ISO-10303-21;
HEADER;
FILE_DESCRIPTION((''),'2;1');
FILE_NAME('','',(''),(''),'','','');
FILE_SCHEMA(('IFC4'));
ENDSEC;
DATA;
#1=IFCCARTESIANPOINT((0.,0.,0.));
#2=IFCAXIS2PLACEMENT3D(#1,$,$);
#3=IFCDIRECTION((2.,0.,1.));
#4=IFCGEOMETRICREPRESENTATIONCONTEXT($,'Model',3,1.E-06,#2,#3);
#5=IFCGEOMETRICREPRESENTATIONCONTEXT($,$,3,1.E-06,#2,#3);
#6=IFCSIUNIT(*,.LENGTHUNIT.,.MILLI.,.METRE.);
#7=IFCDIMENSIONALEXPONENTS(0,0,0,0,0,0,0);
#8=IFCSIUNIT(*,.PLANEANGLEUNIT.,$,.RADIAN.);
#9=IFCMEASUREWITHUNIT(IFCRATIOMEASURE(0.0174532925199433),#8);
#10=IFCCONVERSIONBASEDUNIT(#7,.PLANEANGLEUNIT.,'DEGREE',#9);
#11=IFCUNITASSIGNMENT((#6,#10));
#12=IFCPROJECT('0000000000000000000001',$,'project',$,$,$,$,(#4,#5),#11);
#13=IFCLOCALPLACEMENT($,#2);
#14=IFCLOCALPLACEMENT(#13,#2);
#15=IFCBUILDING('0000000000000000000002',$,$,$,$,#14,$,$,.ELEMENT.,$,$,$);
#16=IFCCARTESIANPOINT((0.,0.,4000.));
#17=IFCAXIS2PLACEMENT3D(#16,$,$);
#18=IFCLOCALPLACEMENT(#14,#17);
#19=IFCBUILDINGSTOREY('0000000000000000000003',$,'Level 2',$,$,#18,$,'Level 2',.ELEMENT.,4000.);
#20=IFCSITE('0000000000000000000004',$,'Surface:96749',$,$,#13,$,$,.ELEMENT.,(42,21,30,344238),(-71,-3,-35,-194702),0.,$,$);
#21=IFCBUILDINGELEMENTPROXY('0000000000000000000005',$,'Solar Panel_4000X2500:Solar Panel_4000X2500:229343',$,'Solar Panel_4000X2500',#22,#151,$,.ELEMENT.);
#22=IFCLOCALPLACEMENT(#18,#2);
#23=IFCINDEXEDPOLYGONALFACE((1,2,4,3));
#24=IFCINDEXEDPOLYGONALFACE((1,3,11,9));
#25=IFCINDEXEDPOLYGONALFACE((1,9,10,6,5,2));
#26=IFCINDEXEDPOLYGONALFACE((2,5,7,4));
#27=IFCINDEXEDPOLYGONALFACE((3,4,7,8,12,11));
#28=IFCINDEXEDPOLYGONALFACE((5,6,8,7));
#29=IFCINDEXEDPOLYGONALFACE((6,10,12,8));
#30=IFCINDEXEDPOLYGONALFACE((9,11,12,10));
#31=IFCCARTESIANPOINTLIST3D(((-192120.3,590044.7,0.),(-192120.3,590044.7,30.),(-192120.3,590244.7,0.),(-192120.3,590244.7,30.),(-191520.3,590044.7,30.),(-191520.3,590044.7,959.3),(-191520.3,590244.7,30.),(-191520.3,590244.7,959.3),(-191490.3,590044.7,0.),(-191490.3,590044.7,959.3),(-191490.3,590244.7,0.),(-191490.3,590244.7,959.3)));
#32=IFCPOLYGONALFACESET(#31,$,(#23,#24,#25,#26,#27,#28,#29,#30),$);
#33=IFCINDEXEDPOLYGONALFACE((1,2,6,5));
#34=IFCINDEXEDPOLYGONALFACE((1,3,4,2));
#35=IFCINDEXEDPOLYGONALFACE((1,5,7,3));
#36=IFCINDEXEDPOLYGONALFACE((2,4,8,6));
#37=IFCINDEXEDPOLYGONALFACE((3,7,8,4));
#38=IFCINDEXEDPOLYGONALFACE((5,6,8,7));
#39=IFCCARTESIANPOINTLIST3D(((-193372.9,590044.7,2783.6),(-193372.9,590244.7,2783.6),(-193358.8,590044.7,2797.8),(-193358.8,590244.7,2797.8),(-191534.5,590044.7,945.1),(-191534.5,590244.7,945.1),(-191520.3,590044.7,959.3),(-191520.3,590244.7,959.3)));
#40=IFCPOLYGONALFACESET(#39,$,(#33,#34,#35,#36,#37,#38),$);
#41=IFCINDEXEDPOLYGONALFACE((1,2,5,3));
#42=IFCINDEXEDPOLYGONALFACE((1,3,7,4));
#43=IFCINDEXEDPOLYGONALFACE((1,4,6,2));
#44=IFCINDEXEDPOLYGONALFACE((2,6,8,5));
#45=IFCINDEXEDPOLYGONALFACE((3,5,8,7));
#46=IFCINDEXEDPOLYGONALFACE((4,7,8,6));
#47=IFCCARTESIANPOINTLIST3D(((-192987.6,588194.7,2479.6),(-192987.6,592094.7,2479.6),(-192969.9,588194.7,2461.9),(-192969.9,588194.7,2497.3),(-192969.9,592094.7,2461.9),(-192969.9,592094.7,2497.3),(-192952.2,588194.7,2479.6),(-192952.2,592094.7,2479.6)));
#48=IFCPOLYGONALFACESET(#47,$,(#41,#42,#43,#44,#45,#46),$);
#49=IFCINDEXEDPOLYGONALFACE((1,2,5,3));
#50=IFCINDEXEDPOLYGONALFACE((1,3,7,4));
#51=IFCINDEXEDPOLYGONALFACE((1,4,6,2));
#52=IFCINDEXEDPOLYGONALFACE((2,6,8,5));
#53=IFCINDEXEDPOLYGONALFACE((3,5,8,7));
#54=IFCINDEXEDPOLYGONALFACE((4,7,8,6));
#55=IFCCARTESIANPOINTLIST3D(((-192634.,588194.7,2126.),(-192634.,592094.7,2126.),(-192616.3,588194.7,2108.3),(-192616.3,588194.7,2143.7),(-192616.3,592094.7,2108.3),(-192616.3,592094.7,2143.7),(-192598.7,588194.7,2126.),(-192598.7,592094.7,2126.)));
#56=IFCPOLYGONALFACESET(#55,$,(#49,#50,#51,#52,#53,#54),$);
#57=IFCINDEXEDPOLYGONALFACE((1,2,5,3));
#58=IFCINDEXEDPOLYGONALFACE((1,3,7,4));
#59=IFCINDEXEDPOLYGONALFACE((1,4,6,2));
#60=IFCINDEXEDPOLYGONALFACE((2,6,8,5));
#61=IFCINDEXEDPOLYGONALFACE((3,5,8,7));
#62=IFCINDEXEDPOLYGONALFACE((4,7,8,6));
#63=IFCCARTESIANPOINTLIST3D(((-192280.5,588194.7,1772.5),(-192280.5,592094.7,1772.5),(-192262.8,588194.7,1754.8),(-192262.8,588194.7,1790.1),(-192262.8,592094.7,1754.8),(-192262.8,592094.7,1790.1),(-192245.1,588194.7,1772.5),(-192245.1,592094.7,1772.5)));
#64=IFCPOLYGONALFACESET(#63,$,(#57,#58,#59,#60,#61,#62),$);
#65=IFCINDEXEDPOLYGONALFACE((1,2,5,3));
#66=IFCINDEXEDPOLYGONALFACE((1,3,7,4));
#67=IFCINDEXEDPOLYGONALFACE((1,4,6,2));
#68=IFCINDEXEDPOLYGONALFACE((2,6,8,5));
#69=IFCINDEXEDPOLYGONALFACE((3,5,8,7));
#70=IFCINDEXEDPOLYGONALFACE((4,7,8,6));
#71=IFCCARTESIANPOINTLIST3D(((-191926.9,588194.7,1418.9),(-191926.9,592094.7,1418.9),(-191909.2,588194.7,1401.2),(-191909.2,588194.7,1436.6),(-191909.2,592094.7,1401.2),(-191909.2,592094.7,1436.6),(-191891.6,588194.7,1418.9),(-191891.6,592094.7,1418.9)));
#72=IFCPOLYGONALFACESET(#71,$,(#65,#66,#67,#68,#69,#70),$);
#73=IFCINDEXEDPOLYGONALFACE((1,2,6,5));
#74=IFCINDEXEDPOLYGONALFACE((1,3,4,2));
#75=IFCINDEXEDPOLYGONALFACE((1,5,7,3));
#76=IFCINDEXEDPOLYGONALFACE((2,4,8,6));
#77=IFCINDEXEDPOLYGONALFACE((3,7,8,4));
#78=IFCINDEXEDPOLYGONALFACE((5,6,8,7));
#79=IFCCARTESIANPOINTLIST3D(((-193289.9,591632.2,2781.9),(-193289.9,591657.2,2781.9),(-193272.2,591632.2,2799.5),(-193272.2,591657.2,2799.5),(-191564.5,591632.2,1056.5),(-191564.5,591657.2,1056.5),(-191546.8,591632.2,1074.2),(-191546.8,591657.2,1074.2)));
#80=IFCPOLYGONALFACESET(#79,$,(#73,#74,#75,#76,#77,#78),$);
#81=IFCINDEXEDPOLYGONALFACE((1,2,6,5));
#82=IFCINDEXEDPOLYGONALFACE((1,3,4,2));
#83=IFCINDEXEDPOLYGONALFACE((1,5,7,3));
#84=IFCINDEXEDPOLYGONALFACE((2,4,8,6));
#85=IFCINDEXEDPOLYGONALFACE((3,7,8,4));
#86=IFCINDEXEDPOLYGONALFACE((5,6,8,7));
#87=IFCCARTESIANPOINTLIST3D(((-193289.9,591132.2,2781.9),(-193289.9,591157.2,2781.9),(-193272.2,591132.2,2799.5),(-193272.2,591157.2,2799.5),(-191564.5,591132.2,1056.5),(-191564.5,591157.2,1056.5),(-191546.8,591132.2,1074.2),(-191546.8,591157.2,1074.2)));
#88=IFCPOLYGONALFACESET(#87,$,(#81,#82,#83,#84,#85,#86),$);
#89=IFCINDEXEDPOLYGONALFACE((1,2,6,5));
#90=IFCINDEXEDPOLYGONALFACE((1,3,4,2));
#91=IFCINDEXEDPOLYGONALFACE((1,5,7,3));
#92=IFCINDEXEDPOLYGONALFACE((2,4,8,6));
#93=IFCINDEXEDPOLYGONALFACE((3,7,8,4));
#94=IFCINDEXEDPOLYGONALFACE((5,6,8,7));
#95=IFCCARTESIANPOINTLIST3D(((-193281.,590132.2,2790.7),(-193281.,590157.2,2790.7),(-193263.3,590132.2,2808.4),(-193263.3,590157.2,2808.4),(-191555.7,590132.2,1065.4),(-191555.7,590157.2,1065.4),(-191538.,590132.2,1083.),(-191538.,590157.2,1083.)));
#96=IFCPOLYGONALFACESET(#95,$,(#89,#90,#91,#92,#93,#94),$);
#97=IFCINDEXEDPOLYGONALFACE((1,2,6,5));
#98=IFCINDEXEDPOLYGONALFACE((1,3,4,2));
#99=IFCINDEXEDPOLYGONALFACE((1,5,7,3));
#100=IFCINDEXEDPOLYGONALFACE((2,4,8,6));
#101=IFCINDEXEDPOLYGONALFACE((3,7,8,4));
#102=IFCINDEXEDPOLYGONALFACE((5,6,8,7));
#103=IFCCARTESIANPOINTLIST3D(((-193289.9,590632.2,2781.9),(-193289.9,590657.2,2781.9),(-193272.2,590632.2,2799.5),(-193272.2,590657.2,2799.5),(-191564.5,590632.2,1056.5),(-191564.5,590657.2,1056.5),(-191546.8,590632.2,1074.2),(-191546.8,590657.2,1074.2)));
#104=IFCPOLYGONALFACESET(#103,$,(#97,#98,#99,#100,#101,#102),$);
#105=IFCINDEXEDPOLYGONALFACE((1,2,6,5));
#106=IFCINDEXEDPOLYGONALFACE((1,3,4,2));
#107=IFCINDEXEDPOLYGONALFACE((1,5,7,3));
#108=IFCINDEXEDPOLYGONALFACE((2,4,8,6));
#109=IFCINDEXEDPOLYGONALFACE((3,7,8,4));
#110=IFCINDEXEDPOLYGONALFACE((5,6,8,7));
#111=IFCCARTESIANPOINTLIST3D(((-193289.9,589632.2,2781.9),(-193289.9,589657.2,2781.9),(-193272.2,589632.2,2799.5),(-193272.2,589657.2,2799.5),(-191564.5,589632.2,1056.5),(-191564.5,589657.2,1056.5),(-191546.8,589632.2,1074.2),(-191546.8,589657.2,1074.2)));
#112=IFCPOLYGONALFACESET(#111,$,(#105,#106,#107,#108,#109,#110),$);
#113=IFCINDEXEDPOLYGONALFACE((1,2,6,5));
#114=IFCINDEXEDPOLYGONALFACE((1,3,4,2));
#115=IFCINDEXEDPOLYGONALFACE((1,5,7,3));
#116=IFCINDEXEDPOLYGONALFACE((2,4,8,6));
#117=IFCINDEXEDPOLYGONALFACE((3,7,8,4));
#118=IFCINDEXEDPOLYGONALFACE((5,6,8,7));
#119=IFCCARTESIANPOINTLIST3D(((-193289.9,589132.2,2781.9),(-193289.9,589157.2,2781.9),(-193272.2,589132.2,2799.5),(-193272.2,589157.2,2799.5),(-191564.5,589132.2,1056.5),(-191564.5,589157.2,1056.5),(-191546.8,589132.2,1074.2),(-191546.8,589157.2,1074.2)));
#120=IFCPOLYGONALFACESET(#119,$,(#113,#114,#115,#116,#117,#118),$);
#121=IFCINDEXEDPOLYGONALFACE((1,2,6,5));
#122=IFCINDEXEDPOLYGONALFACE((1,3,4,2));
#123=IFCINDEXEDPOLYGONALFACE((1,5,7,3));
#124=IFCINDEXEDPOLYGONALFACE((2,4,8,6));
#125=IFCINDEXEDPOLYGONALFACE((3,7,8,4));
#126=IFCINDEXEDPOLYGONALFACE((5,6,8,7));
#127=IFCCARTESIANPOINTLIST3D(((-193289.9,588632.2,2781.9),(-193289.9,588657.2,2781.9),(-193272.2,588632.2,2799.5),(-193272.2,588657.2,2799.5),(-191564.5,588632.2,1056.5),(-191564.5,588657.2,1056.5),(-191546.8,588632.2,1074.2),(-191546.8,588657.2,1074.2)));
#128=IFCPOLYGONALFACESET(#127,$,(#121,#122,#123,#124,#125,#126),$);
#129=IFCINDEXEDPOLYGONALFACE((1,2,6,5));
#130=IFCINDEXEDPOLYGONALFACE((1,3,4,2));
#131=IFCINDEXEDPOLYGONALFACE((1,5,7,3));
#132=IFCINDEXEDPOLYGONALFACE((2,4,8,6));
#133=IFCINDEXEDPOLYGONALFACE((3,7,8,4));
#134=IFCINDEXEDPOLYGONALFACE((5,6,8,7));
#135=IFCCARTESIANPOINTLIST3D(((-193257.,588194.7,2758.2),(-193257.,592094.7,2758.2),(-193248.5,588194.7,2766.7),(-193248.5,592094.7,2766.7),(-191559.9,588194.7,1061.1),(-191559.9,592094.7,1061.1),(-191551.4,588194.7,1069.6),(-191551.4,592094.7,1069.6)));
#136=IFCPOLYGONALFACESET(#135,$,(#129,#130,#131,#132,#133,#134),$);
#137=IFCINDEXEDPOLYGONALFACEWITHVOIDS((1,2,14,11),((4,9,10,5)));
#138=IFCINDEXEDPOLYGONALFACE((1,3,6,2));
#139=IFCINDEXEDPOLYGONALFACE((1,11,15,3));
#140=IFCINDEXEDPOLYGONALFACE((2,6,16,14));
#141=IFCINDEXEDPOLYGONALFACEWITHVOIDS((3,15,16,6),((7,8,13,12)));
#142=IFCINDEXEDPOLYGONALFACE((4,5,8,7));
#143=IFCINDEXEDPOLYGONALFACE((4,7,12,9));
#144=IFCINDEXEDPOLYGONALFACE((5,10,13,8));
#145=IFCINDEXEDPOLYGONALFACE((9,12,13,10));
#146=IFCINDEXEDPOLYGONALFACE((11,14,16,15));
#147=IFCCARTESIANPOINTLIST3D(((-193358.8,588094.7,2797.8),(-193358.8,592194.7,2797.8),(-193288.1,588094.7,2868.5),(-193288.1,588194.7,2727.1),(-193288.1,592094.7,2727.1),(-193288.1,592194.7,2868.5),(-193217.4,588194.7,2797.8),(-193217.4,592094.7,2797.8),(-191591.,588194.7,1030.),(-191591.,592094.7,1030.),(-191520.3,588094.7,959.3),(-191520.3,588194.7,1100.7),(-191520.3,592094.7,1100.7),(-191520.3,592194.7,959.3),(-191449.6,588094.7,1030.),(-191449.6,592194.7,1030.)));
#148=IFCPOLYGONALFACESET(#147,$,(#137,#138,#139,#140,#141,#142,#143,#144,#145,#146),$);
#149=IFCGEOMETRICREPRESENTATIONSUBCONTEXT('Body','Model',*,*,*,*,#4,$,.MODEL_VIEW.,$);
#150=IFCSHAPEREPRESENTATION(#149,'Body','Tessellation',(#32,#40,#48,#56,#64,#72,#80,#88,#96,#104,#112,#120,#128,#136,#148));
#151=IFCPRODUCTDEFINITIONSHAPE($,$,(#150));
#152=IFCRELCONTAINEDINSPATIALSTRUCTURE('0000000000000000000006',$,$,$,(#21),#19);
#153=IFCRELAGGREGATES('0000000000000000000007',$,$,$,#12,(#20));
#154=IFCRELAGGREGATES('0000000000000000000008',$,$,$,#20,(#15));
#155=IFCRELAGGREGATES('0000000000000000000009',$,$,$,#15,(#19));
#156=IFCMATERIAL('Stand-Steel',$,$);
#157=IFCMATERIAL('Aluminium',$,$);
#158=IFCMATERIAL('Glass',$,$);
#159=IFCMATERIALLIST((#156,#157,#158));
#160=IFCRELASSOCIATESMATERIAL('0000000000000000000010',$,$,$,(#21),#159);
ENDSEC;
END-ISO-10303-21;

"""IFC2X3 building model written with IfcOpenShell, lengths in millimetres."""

from ifc_helpers import new_model, entity, si_unit, converted_unit, direction, frame, frame_2d, origin, origin_2d_with_axis, place, context, subcontext, project, spatial, polyline, rectangle, outline, extrude, source, transform, mapped, material, material_list, element, save


model = new_model("IFC2X3")

# Units and contexts
model_context = context("Model", 3, precision=1e-06, world=origin(), true_north=direction((2.0, 0.0, 1.0)))
context_of_model = context(None, 3, precision=1e-06, world=origin(), true_north=direction((2.0, 0.0, 1.0)))
body_context = subcontext(model_context, "Body", "Model", "MODEL_VIEW")
ifc_project = project(units=[si_unit("LENGTHUNIT", "METRE", prefix="MILLI"), converted_unit("PLANEANGLEUNIT", "DEGREE", entity("IfcRatioMeasure", 0.0174532925199433), si_unit("PLANEANGLEUNIT", "RADIAN"), dimensions=[0, 0, 0, 0, 0, 0, 0])], contexts=[model_context, context_of_model])

# Site, building, storey
site_placement = place(None, origin())
site = spatial("IfcSite", under=ifc_project, at=site_placement, Name="Surface:96749", CompositionType="ELEMENT", RefLatitude=(42, 21, 30, 344238), RefLongitude=(-71, -3, -35, -194702), RefElevation=0.0)
building_placement = place(site_placement, origin())
building = spatial("IfcBuilding", under=site, at=building_placement, CompositionType="ELEMENT")
storey_placement = place(building_placement, frame((0.0, 0.0, 4000.0)))
storey = spatial("IfcBuildingStorey", under=building, at=storey_placement, Name="Level 2", LongName="Level 2", CompositionType="ELEMENT", Elevation=4000.0)

# Building element proxy
ifc_material_1 = material(Name="Stand-Steel")
ifc_material_2 = material(Name="Aluminium")
ifc_material_3 = material(Name="Glass")
shared_shape = source(origin(), body_context, "Body", "SweptSolid", [
    extrude(outline(polyline([(-629.5, -220.0), (329.8, -220.0), (329.8, 410.0), (299.8, 410.0), (299.8, -190.0), (-629.5, -190.0), (-629.5, -220.0)])), frame((-190.0, -100.0, 299.8), z_axis=(0.0, 1.0, 0.0), x_axis=(0.0, 0.0, -1.0)), (0.0, 0.0, 1.0), 200.0),
    extrude(rectangle(XDim=20.0, YDim=200.0, at=frame_2d((0.0, 0.0), x_axis=(0.0, 1.0))), frame((-7.1, 0.0, 922.2), z_axis=(-0.707107, 0.0, 0.707107), x_axis=(0.0, 1.0, 0.0)), (0.0, 0.0, 1.0), 2600.0),
    extrude(rectangle(XDim=25.0, YDim=25.0, at=frame_2d((0.0, 0.0), x_axis=(1.0, 0.0))), frame((-1449.6, -1950.0, 2449.6), z_axis=(0.0, 1.0, 0.0), x_axis=(-0.707107, 0.0, -0.707107)), (0.0, 0.0, 1.0), 3900.0),
    extrude(rectangle(XDim=25.0, YDim=25.0, at=origin_2d_with_axis()), frame((-1096.0, -1950.0, 2096.0), z_axis=(0.0, 1.0, 0.0), x_axis=(-0.707107, 0.0, -0.707107)), (0.0, 0.0, 1.0), 3900.0),
    extrude(rectangle(XDim=25.0, YDim=25.0, at=origin_2d_with_axis()), frame((-742.5, -1950.0, 1742.5), z_axis=(0.0, 1.0, 0.0), x_axis=(-0.707107, 0.0, -0.707107)), (0.0, 0.0, 1.0), 3900.0),
    extrude(rectangle(XDim=25.0, YDim=25.0, at=frame_2d((0.0, 0.0), x_axis=(1.0, 0.0))), frame((-388.9, -1950.0, 1388.9), z_axis=(0.0, 1.0, 0.0), x_axis=(-0.707107, 0.0, -0.707107)), (0.0, 0.0, 1.0), 3900.0),
    extrude(rectangle(XDim=25.0, YDim=25.0, at=frame_2d((0.0, 0.0), x_axis=(0.0, 1.0))), frame((-35.4, 1500.0, 1035.4), z_axis=(-0.707107, 0.0, 0.707107), x_axis=(0.0, 1.0, 0.0)), (0.0, 0.0, 1.0), 2440.0),
    extrude(rectangle(XDim=25.0, YDim=25.0, at=frame_2d((0.0, 0.0), x_axis=(0.0, 1.0))), frame((-35.4, 1000.0, 1035.4), z_axis=(-0.707107, 0.0, 0.707107), x_axis=(0.0, 1.0, 0.0)), (0.0, 0.0, 1.0), 2440.0),
    extrude(rectangle(XDim=25.0, YDim=25.0, at=frame_2d((0.0, 0.0), x_axis=(0.0, 1.0))), frame((-26.5, 0.0, 1044.2), z_axis=(-0.707107, 0.0, 0.707107), x_axis=(0.0, -1.0, 0.0)), (0.0, 0.0, 1.0), 2440.0),
    extrude(rectangle(XDim=25.0, YDim=25.0, at=frame_2d((0.0, 0.0), x_axis=(0.0, 1.0))), frame((-35.4, 500.0, 1035.4), z_axis=(-0.707107, 0.0, 0.707107), x_axis=(0.0, 1.0, 0.0)), (0.0, 0.0, 1.0), 2440.0),
    extrude(rectangle(XDim=25.0, YDim=25.0, at=frame_2d((0.0, 0.0), x_axis=(0.0, 1.0))), frame((-35.4, -500.0, 1035.4), z_axis=(-0.707107, 0.0, 0.707107), x_axis=(0.0, 1.0, 0.0)), (0.0, 0.0, 1.0), 2440.0),
    extrude(rectangle(XDim=25.0, YDim=25.0, at=frame_2d((0.0, 0.0), x_axis=(0.0, 1.0))), frame((-35.4, -1000.0, 1035.4), z_axis=(-0.707107, 0.0, 0.707107), x_axis=(0.0, 1.0, 0.0)), (0.0, 0.0, 1.0), 2440.0),
    extrude(rectangle(XDim=25.0, YDim=25.0, at=frame_2d((0.0, 0.0), x_axis=(0.0, 1.0))), frame((-35.4, -1500.0, 1035.4), z_axis=(-0.707107, 0.0, 0.707107), x_axis=(0.0, 1.0, 0.0)), (0.0, 0.0, 1.0), 2440.0),
    extrude(rectangle(XDim=2400.0, YDim=12.0, at=frame_2d((0.0, 0.0), x_axis=(1.0, 0.0))), frame((-883.9, -1950.0, 1883.9), z_axis=(0.0, 1.0, 0.0), x_axis=(0.707107, 0.0, -0.707107)), (0.0, 0.0, 1.0), 3900.0),
    extrude(outline(polyline([(-2050.0, -1300.0), (2050.0, -1300.0), (2050.0, 1300.0), (-2050.0, 1300.0), (-2050.0, -1300.0)]), holes=[polyline([(1950.0, -1200.0), (-1950.0, -1200.0), (-1950.0, 1200.0), (1950.0, 1200.0), (1950.0, -1200.0)])]), frame((-919.2, 0.0, 1848.5), z_axis=(0.707107, 0.0, 0.707107), x_axis=(0.0, 1.0, 0.0)), (0.0, 0.0, 1.0), 100.0),
])
ifc_material_list_1 = material_list([ifc_material_1, ifc_material_2, ifc_material_3])
proxy_1_placement = place(storey_placement, frame((-191520.3, 590144.7, 30.0)))
element("IfcBuildingElementProxy", 1, at=proxy_1_placement, inside=storey, material=ifc_material_list_1, Name="Solar Panel_4000X2500:Solar Panel_4000X2500:229343", ObjectType="Solar Panel_4000X2500", CompositionType="ELEMENT", context=body_context, shape_type="MappedRepresentation", body=[
    mapped(shared_shape, transform((0.0, 0.0, 0.0), scale=1.0)),
])

save(model, "model.ifc")
